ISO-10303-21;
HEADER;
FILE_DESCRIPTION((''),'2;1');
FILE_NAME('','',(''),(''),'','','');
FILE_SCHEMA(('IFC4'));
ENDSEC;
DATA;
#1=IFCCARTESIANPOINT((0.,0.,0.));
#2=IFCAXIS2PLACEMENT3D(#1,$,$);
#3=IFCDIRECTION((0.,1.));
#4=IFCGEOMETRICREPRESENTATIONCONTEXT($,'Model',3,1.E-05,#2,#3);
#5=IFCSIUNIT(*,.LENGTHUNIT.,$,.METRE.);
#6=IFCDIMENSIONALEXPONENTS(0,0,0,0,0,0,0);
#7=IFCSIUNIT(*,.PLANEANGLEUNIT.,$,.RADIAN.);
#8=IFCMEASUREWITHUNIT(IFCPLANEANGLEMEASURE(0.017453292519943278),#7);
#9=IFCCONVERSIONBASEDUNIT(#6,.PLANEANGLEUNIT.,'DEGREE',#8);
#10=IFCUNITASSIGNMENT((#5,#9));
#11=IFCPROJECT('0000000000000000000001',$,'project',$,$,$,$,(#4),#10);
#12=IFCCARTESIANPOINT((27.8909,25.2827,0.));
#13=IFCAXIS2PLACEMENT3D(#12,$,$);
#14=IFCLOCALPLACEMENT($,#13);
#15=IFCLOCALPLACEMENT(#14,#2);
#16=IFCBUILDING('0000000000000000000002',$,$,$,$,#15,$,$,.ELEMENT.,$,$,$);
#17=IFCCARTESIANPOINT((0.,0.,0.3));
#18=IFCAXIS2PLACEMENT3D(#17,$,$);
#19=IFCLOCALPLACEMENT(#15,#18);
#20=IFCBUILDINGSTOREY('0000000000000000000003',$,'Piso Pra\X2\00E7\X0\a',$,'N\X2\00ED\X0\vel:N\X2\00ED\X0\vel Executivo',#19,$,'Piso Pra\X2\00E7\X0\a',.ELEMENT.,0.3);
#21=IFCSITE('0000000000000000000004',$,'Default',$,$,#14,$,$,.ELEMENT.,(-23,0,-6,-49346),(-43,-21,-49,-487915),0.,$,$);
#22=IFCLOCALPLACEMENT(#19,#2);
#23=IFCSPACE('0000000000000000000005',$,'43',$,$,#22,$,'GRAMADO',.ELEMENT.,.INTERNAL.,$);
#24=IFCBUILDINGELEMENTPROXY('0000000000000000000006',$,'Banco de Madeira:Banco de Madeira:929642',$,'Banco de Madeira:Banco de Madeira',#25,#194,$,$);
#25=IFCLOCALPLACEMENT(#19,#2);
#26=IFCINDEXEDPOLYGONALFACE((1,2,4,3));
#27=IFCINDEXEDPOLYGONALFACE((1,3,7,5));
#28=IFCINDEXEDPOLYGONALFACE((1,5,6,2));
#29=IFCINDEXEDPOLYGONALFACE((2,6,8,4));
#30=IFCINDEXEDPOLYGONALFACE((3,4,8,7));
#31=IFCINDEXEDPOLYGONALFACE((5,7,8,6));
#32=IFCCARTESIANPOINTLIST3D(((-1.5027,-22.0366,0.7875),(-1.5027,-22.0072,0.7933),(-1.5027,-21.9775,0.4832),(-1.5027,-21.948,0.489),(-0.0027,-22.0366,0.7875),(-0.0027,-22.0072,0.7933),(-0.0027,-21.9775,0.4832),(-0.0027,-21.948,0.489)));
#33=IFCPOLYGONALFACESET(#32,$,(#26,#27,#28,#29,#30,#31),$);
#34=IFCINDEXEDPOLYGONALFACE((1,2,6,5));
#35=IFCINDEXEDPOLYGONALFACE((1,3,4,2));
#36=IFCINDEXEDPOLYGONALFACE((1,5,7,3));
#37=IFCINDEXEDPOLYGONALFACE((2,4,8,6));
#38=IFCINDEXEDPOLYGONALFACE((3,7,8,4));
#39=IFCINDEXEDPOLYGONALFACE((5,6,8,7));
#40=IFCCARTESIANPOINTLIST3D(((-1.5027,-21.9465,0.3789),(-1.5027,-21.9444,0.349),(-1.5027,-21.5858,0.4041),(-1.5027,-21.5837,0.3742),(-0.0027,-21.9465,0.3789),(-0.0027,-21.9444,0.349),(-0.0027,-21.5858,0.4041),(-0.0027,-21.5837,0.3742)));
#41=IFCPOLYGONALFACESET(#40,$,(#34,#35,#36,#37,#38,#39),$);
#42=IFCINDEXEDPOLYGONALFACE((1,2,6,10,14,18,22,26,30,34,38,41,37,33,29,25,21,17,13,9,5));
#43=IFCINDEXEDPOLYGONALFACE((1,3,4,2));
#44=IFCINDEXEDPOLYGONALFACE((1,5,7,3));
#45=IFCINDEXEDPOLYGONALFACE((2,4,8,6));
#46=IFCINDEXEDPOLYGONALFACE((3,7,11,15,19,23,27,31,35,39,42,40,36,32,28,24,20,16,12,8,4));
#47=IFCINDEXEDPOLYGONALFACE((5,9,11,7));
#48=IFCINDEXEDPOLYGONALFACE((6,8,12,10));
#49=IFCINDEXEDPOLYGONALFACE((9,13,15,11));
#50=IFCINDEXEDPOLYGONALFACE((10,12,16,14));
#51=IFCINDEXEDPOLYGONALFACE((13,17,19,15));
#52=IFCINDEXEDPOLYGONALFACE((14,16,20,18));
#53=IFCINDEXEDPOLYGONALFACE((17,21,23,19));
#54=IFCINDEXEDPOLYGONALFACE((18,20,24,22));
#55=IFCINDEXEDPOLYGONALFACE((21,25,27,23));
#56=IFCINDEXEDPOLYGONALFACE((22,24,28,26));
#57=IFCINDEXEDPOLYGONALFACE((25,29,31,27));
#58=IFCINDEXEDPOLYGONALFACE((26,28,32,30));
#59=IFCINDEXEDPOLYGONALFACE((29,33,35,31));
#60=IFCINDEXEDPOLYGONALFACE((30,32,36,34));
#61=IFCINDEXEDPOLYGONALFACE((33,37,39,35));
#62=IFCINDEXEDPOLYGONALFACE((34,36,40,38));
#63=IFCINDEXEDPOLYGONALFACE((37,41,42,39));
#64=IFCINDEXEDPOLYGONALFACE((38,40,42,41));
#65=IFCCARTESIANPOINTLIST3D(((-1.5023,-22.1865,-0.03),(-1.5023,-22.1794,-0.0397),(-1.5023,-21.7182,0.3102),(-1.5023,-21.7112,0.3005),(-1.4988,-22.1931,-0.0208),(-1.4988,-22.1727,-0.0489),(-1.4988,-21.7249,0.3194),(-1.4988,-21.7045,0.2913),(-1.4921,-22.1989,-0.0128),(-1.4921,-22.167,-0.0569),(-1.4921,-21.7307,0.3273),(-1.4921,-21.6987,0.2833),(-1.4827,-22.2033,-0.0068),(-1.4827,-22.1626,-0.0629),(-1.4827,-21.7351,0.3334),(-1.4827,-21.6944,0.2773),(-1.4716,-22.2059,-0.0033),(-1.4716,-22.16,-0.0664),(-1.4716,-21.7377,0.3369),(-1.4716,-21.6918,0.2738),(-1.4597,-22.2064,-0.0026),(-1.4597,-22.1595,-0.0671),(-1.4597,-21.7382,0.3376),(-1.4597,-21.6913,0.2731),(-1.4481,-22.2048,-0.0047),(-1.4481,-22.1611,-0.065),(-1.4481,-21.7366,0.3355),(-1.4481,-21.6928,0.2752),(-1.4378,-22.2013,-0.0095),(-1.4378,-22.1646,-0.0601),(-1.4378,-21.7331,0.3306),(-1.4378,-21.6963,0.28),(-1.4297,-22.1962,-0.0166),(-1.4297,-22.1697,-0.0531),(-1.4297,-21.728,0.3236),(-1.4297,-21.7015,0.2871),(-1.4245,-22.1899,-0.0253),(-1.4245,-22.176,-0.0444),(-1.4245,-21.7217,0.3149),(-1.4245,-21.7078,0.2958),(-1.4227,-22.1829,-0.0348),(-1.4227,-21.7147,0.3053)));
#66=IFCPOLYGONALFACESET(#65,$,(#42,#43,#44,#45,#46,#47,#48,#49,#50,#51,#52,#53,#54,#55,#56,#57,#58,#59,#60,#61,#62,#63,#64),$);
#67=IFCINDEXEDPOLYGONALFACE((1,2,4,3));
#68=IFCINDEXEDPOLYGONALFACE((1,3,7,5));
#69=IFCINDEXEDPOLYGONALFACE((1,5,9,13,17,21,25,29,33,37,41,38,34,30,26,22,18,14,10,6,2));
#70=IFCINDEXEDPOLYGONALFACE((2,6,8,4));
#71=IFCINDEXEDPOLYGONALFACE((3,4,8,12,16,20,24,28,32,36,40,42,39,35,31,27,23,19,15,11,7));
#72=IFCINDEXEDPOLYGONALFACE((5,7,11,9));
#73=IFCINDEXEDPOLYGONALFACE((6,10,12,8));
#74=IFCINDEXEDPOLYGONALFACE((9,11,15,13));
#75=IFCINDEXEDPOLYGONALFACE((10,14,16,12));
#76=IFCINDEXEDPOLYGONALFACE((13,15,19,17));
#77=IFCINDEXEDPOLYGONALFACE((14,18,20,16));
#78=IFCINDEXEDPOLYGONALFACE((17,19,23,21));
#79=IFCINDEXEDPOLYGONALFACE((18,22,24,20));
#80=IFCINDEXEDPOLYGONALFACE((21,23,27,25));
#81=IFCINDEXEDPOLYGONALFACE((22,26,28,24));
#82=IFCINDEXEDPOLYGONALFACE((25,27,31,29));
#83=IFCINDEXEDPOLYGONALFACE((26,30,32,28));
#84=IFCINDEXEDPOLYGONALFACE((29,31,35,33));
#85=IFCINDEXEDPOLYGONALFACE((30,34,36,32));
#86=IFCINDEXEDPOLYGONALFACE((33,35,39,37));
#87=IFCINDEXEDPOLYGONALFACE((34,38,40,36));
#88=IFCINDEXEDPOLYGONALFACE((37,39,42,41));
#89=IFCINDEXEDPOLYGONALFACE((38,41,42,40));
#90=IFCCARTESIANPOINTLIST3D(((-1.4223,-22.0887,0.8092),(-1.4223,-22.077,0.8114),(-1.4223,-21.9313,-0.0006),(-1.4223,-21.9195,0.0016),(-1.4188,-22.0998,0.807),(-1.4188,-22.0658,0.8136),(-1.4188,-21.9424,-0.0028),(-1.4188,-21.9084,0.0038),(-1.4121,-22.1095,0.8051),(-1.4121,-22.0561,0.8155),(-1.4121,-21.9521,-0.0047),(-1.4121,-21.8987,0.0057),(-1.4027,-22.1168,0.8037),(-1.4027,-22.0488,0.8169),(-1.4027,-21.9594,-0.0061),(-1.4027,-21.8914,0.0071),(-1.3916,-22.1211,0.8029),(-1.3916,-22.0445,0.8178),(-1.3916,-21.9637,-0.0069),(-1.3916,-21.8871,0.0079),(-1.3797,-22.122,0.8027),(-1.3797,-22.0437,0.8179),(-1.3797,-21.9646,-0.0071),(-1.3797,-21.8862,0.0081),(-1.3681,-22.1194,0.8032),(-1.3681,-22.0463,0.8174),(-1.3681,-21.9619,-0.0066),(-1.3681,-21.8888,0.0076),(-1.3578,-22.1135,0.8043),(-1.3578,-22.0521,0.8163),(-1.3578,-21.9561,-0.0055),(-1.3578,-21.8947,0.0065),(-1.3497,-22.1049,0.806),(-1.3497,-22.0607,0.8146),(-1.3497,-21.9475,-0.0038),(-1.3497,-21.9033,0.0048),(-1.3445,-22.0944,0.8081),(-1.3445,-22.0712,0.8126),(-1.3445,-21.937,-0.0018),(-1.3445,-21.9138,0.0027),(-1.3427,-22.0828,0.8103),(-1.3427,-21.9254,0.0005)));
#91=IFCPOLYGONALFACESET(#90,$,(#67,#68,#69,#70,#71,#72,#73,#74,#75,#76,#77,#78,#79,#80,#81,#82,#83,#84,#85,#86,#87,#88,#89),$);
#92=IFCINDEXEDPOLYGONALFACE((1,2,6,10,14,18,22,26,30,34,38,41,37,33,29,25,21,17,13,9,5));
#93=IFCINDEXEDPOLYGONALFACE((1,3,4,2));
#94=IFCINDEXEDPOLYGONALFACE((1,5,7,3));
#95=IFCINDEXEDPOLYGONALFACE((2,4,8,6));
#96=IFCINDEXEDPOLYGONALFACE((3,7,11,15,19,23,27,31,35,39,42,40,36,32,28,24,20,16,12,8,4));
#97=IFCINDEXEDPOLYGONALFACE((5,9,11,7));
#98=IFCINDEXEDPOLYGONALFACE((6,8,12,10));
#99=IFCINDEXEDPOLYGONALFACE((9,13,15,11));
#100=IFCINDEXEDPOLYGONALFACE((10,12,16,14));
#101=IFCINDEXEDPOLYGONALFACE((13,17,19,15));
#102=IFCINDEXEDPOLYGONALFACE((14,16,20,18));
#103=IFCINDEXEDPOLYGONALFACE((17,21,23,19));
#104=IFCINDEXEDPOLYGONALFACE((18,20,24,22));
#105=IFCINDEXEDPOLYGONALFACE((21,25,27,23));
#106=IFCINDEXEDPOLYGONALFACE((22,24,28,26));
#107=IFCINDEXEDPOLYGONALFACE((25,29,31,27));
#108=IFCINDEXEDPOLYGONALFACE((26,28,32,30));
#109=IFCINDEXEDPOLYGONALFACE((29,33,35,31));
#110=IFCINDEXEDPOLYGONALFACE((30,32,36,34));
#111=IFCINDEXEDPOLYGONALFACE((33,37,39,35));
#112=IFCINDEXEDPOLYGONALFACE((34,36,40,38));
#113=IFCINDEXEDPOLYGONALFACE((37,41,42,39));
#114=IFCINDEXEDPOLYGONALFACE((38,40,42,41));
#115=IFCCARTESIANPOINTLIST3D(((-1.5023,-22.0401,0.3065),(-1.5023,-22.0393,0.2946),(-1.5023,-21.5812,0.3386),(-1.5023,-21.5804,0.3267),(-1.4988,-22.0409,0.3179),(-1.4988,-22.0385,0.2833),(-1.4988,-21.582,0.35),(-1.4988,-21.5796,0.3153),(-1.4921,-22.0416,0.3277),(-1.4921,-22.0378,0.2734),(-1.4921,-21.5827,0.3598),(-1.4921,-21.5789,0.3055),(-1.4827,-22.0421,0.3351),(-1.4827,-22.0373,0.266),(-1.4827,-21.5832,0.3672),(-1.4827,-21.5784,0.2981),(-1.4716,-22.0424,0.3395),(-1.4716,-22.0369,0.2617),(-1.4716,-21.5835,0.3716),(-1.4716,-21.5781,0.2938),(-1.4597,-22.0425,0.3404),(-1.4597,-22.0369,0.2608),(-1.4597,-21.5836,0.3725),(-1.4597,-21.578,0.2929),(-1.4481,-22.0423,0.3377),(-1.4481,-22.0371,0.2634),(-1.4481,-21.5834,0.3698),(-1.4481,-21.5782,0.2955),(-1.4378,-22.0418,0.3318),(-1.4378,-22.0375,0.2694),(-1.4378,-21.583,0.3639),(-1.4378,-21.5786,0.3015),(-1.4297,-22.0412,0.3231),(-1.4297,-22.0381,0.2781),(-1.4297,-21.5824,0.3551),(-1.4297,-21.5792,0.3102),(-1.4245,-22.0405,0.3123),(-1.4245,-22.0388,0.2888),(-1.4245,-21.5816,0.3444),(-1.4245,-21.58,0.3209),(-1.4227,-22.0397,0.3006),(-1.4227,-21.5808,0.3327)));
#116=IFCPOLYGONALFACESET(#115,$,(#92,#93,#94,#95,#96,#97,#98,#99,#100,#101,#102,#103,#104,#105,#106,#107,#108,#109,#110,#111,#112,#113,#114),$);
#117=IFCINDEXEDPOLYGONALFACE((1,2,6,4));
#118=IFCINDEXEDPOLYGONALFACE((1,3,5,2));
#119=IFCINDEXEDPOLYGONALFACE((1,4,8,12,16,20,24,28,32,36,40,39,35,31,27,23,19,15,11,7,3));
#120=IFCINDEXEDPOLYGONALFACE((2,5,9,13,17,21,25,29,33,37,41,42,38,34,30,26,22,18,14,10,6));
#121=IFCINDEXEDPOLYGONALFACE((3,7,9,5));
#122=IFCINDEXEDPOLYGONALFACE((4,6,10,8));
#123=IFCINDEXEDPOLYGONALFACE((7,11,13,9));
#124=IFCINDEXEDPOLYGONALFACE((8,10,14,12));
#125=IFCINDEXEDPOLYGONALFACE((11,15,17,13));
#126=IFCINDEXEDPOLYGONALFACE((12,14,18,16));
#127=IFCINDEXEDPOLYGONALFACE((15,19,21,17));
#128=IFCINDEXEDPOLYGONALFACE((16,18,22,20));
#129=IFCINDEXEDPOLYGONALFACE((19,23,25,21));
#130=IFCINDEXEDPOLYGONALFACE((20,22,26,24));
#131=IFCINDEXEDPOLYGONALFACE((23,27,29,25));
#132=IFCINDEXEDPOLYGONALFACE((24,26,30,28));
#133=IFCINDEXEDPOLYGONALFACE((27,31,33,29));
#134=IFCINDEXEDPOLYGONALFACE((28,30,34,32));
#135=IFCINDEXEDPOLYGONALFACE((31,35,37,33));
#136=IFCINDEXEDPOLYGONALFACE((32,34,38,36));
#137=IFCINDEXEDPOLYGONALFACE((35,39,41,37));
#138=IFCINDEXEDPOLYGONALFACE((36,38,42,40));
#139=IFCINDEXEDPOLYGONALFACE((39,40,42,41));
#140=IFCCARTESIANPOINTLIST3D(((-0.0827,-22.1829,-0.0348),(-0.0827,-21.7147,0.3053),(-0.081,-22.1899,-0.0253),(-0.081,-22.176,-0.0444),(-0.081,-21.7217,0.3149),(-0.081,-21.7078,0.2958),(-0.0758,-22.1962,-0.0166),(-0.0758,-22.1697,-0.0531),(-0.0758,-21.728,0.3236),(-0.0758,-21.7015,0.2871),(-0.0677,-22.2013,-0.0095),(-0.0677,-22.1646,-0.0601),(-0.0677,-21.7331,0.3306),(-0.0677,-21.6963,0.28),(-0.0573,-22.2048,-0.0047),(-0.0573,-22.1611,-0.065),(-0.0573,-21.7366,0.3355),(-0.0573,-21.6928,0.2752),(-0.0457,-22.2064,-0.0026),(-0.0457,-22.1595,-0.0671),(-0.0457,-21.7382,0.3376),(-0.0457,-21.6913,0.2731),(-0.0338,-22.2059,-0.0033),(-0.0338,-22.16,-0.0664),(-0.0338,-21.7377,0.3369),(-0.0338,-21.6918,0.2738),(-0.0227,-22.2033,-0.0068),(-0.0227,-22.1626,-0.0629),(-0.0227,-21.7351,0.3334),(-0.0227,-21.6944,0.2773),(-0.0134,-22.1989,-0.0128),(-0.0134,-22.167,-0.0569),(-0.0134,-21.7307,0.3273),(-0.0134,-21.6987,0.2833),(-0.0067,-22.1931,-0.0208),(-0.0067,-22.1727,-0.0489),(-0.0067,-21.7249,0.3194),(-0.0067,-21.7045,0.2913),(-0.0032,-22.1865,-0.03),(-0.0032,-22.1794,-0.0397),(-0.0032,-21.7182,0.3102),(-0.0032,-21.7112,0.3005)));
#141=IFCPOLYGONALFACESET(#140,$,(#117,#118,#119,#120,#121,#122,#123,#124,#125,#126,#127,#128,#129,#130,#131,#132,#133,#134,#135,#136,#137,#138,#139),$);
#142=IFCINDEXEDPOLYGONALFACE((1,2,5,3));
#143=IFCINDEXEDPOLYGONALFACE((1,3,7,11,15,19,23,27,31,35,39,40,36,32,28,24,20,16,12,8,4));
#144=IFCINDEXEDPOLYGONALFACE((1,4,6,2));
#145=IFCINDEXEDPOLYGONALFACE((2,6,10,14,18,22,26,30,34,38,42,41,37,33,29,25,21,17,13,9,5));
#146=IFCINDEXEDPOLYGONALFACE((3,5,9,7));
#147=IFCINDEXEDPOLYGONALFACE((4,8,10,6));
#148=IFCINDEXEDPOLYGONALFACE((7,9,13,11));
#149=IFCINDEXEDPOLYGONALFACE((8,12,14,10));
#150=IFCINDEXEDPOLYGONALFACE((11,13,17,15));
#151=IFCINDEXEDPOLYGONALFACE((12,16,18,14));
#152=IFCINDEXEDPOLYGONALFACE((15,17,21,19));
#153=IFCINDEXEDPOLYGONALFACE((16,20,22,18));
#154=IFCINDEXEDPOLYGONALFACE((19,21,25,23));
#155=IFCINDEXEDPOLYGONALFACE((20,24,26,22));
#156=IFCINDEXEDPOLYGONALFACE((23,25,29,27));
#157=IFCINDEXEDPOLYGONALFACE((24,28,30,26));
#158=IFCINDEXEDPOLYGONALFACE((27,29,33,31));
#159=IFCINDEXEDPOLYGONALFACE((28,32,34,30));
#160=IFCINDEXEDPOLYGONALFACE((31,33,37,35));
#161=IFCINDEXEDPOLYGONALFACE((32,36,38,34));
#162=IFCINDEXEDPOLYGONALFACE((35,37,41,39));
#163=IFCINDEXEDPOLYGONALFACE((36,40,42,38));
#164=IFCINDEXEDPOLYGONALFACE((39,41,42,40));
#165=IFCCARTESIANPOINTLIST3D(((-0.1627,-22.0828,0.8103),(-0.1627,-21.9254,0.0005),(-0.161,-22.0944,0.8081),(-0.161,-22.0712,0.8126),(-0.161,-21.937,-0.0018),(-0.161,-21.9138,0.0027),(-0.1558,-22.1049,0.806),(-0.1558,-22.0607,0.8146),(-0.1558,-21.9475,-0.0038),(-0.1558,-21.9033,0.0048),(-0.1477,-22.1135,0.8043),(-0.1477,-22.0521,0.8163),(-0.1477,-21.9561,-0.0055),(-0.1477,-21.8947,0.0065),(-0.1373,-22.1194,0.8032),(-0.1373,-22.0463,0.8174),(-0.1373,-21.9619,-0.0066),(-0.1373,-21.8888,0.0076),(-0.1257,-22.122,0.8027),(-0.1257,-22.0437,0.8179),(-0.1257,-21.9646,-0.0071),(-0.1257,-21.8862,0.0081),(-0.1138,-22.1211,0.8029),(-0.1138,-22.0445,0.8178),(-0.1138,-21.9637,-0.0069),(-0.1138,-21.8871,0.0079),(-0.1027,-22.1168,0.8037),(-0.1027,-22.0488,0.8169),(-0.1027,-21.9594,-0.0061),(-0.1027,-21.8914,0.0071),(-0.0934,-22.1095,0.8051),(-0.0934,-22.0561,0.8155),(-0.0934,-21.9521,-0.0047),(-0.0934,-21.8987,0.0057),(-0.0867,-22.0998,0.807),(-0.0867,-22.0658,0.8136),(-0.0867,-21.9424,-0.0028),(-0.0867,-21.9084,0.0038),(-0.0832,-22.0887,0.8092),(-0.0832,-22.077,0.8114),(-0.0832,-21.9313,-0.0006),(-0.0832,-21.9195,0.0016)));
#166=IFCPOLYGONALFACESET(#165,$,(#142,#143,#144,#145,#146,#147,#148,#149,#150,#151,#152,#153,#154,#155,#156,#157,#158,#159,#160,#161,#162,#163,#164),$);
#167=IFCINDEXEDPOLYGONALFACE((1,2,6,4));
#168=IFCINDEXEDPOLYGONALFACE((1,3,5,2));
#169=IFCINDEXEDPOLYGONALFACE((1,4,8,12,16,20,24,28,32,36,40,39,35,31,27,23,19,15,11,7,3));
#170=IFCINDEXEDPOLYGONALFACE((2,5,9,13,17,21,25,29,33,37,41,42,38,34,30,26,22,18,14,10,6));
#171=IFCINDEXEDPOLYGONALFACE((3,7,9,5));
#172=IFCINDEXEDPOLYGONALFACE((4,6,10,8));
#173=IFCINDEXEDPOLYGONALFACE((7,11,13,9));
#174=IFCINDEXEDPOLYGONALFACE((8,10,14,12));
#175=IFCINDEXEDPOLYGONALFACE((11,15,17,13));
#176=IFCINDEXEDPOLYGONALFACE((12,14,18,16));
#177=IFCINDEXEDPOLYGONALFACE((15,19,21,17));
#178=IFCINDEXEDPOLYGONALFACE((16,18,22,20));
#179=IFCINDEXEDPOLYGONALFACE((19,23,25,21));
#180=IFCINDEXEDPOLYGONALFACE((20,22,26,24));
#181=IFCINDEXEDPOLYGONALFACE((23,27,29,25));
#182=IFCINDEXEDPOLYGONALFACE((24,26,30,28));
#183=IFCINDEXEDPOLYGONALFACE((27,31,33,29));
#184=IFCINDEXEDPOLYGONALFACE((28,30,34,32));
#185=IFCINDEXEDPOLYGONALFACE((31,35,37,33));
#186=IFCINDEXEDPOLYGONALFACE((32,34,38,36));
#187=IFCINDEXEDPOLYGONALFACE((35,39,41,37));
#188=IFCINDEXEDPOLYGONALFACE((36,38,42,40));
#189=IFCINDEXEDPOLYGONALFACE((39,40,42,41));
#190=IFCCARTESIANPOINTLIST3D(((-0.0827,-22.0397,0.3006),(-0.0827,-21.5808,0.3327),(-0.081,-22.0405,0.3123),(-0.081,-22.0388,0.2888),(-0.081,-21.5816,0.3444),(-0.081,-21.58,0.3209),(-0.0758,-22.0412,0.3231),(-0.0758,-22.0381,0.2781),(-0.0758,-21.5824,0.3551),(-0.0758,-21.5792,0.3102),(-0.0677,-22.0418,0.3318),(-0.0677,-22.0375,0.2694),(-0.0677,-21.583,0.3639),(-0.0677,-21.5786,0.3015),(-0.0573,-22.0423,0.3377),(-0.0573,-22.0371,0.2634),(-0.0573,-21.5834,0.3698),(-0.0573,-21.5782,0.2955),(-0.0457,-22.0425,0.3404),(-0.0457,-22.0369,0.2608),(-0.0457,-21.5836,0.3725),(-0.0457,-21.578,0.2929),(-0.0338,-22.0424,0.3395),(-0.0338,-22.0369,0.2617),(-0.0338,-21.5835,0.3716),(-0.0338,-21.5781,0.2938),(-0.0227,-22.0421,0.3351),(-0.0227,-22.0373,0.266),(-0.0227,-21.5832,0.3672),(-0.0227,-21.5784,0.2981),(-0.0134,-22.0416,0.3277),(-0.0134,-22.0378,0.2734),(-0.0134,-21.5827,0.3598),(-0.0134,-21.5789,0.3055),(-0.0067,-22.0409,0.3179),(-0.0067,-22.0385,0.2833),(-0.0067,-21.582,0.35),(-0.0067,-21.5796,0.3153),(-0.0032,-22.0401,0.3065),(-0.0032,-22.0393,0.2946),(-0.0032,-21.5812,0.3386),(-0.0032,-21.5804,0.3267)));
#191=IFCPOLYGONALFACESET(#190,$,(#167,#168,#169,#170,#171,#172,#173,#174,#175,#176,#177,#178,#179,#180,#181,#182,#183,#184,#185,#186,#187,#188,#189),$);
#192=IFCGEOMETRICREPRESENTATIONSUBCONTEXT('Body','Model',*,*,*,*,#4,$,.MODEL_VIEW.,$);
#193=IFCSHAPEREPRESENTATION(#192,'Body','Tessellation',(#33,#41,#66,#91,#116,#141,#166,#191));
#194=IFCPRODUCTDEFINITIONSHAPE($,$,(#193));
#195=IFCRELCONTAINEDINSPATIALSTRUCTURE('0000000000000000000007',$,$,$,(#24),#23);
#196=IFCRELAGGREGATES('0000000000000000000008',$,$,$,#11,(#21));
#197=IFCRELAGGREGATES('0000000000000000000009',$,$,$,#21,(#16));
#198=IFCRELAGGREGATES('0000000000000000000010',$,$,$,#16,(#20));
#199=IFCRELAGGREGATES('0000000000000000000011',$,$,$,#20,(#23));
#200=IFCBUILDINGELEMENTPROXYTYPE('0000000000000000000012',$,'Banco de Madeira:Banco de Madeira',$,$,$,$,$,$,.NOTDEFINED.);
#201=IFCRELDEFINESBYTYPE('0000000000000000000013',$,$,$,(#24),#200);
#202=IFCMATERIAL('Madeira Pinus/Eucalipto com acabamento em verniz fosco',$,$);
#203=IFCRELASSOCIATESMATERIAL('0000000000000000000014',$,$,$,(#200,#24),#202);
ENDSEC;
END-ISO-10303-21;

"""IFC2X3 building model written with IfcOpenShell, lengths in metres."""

from ifc_helpers import new_model, entity, si_unit, converted_unit, direction, frame, frame_2d, origin, place, context, subcontext, project, spatial, rectangle, circle, extrude, source, transform, mapped, material, type_object, type_shapes, element, save


model = new_model("IFC2X3")

# Units and contexts
model_context = context("Model", 3, precision=1e-05, world=origin(), true_north=direction((0.0, 1.0)))
body_context = subcontext(model_context, "Body", "Model", "MODEL_VIEW")
ifc_project = project(units=[si_unit("LENGTHUNIT", "METRE"), converted_unit("PLANEANGLEUNIT", "DEGREE", entity("IfcPlaneAngleMeasure", 0.017453292519943278), si_unit("PLANEANGLEUNIT", "RADIAN"), dimensions=[0, 0, 0, 0, 0, 0, 0])], contexts=[model_context])

# Site, building, storey
site_placement = place(None, frame((27.8909, 25.2827, 0.0)))
site = spatial("IfcSite", under=ifc_project, at=site_placement, Name="Default", CompositionType="ELEMENT", RefLatitude=(-23, 0, -6, -49346), RefLongitude=(-43, -21, -49, -487915), RefElevation=0.0)
building_placement = place(site_placement, origin())
building = spatial("IfcBuilding", under=site, at=building_placement, CompositionType="ELEMENT")
storey_placement = place(building_placement, frame((0.0, 0.0, 0.3)))
storey = spatial("IfcBuildingStorey", under=building, at=storey_placement, Name="Piso Praça", ObjectType="Nível:Nível Executivo", LongName="Piso Praça", CompositionType="ELEMENT", Elevation=0.3)

# Shared definitions
space_1_placement = place(storey_placement, origin())
space_1 = spatial("IfcSpace", under=storey, at=space_1_placement, Name="43", LongName="GRAMADO", CompositionType="ELEMENT", InteriorOrExteriorSpace="INTERNAL")

# Building element proxy
ifc_material_1 = material(Name="Madeira Pinus/Eucalipto com acabamento em verniz fosco")
building_element_proxy_type_1 = type_object("IfcBuildingElementProxyType", Name="Banco de Madeira:Banco de Madeira", PredefinedType="NOTDEFINED", material=ifc_material_1)
shared_shape_1 = source(origin(), body_context, "Body", "SweptSolid", [
    extrude(rectangle(XDim=0.31, YDim=0.03, at=frame_2d((0.0, 0.0), x_axis=(1.0, 0.0))), frame((-0.75, 0.1439, 0.6383), z_axis=(1.0, 0.0, 0.0), x_axis=(0.0, 0.190809, 0.981627)), (0.0, 0.0, 1.0), 1.5),
    extrude(rectangle(XDim=0.03, YDim=0.3616, at=frame_2d((0.0, 0.0), x_axis=(0.0, 1.0))), frame((-0.75, -0.0833, 0.3765), z_axis=(1.0, 0.0, 0.0), x_axis=(0.0, 0.997564, -0.069756)), (0.0, 0.0, 1.0), 1.5),
    extrude(circle(Radius=0.04, at=frame_2d((0.0, 0.0), x_axis=(1.0, 0.0))), frame((0.71, 0.3345, -0.0348), z_axis=(0.0, -0.809017, 0.587785), x_axis=(-1.0, 0.0, 0.0)), (0.0, 0.0, 1.0), 0.5788),
    extrude(circle(Radius=0.04, at=frame_2d((0.0, 0.0), x_axis=(1.0, 0.0))), frame((0.63, 0.077, 0.0005), z_axis=(0.0, 0.190809, 0.981627), x_axis=(-1.0, 0.0, 0.0)), (0.0, 0.0, 1.0), 0.825),
    extrude(circle(Radius=0.04, at=frame_2d((0.0, 0.0), x_axis=(1.0, 0.0))), frame((0.71, -0.2676, 0.3327), z_axis=(0.0, 0.997564, -0.069756), x_axis=(-1.0, 0.0, 0.0)), (0.0, 0.0, 1.0), 0.46),
    extrude(circle(Radius=0.04, at=frame_2d((0.0, 0.0), x_axis=(1.0, 0.0))), frame((-0.71, 0.3345, -0.0348), z_axis=(0.0, -0.809017, 0.587785), x_axis=(1.0, 0.0, 0.0)), (0.0, 0.0, 1.0), 0.5788),
    extrude(circle(Radius=0.04, at=frame_2d((0.0, 0.0), x_axis=(1.0, 0.0))), frame((-0.63, 0.077, 0.0005), z_axis=(0.0, 0.190809, 0.981627), x_axis=(1.0, 0.0, 0.0)), (0.0, 0.0, 1.0), 0.825),
    extrude(circle(Radius=0.04, at=frame_2d((0.0, 0.0), x_axis=(1.0, 0.0))), frame((-0.71, -0.2676, 0.3327), z_axis=(0.0, 0.997564, -0.069756), x_axis=(1.0, 0.0, 0.0)), (0.0, 0.0, 1.0), 0.46),
])
type_shapes(building_element_proxy_type_1, [shared_shape_1])
for number, where, z_axis, x_axis, name in (
    (1, (-0.7527, -21.8484, 0.0), (0.0, 0.0, 1.0), (-1.0, 0.0, 0.0), "Banco de Madeira:Banco de Madeira:929642"),
):
    element("IfcBuildingElementProxy", number, at=place(space_1_placement, frame(where, z_axis=z_axis, x_axis=x_axis)), inside=space_1, type_object=building_element_proxy_type_1, material=ifc_material_1, Name=name, ObjectType="Banco de Madeira:Banco de Madeira", context=body_context, shape_type="MappedRepresentation", body=[
        mapped(shared_shape_1, transform((0.0, 0.0, 0.0), scale=1.0)),
    ])

save(model, "model.ifc")
